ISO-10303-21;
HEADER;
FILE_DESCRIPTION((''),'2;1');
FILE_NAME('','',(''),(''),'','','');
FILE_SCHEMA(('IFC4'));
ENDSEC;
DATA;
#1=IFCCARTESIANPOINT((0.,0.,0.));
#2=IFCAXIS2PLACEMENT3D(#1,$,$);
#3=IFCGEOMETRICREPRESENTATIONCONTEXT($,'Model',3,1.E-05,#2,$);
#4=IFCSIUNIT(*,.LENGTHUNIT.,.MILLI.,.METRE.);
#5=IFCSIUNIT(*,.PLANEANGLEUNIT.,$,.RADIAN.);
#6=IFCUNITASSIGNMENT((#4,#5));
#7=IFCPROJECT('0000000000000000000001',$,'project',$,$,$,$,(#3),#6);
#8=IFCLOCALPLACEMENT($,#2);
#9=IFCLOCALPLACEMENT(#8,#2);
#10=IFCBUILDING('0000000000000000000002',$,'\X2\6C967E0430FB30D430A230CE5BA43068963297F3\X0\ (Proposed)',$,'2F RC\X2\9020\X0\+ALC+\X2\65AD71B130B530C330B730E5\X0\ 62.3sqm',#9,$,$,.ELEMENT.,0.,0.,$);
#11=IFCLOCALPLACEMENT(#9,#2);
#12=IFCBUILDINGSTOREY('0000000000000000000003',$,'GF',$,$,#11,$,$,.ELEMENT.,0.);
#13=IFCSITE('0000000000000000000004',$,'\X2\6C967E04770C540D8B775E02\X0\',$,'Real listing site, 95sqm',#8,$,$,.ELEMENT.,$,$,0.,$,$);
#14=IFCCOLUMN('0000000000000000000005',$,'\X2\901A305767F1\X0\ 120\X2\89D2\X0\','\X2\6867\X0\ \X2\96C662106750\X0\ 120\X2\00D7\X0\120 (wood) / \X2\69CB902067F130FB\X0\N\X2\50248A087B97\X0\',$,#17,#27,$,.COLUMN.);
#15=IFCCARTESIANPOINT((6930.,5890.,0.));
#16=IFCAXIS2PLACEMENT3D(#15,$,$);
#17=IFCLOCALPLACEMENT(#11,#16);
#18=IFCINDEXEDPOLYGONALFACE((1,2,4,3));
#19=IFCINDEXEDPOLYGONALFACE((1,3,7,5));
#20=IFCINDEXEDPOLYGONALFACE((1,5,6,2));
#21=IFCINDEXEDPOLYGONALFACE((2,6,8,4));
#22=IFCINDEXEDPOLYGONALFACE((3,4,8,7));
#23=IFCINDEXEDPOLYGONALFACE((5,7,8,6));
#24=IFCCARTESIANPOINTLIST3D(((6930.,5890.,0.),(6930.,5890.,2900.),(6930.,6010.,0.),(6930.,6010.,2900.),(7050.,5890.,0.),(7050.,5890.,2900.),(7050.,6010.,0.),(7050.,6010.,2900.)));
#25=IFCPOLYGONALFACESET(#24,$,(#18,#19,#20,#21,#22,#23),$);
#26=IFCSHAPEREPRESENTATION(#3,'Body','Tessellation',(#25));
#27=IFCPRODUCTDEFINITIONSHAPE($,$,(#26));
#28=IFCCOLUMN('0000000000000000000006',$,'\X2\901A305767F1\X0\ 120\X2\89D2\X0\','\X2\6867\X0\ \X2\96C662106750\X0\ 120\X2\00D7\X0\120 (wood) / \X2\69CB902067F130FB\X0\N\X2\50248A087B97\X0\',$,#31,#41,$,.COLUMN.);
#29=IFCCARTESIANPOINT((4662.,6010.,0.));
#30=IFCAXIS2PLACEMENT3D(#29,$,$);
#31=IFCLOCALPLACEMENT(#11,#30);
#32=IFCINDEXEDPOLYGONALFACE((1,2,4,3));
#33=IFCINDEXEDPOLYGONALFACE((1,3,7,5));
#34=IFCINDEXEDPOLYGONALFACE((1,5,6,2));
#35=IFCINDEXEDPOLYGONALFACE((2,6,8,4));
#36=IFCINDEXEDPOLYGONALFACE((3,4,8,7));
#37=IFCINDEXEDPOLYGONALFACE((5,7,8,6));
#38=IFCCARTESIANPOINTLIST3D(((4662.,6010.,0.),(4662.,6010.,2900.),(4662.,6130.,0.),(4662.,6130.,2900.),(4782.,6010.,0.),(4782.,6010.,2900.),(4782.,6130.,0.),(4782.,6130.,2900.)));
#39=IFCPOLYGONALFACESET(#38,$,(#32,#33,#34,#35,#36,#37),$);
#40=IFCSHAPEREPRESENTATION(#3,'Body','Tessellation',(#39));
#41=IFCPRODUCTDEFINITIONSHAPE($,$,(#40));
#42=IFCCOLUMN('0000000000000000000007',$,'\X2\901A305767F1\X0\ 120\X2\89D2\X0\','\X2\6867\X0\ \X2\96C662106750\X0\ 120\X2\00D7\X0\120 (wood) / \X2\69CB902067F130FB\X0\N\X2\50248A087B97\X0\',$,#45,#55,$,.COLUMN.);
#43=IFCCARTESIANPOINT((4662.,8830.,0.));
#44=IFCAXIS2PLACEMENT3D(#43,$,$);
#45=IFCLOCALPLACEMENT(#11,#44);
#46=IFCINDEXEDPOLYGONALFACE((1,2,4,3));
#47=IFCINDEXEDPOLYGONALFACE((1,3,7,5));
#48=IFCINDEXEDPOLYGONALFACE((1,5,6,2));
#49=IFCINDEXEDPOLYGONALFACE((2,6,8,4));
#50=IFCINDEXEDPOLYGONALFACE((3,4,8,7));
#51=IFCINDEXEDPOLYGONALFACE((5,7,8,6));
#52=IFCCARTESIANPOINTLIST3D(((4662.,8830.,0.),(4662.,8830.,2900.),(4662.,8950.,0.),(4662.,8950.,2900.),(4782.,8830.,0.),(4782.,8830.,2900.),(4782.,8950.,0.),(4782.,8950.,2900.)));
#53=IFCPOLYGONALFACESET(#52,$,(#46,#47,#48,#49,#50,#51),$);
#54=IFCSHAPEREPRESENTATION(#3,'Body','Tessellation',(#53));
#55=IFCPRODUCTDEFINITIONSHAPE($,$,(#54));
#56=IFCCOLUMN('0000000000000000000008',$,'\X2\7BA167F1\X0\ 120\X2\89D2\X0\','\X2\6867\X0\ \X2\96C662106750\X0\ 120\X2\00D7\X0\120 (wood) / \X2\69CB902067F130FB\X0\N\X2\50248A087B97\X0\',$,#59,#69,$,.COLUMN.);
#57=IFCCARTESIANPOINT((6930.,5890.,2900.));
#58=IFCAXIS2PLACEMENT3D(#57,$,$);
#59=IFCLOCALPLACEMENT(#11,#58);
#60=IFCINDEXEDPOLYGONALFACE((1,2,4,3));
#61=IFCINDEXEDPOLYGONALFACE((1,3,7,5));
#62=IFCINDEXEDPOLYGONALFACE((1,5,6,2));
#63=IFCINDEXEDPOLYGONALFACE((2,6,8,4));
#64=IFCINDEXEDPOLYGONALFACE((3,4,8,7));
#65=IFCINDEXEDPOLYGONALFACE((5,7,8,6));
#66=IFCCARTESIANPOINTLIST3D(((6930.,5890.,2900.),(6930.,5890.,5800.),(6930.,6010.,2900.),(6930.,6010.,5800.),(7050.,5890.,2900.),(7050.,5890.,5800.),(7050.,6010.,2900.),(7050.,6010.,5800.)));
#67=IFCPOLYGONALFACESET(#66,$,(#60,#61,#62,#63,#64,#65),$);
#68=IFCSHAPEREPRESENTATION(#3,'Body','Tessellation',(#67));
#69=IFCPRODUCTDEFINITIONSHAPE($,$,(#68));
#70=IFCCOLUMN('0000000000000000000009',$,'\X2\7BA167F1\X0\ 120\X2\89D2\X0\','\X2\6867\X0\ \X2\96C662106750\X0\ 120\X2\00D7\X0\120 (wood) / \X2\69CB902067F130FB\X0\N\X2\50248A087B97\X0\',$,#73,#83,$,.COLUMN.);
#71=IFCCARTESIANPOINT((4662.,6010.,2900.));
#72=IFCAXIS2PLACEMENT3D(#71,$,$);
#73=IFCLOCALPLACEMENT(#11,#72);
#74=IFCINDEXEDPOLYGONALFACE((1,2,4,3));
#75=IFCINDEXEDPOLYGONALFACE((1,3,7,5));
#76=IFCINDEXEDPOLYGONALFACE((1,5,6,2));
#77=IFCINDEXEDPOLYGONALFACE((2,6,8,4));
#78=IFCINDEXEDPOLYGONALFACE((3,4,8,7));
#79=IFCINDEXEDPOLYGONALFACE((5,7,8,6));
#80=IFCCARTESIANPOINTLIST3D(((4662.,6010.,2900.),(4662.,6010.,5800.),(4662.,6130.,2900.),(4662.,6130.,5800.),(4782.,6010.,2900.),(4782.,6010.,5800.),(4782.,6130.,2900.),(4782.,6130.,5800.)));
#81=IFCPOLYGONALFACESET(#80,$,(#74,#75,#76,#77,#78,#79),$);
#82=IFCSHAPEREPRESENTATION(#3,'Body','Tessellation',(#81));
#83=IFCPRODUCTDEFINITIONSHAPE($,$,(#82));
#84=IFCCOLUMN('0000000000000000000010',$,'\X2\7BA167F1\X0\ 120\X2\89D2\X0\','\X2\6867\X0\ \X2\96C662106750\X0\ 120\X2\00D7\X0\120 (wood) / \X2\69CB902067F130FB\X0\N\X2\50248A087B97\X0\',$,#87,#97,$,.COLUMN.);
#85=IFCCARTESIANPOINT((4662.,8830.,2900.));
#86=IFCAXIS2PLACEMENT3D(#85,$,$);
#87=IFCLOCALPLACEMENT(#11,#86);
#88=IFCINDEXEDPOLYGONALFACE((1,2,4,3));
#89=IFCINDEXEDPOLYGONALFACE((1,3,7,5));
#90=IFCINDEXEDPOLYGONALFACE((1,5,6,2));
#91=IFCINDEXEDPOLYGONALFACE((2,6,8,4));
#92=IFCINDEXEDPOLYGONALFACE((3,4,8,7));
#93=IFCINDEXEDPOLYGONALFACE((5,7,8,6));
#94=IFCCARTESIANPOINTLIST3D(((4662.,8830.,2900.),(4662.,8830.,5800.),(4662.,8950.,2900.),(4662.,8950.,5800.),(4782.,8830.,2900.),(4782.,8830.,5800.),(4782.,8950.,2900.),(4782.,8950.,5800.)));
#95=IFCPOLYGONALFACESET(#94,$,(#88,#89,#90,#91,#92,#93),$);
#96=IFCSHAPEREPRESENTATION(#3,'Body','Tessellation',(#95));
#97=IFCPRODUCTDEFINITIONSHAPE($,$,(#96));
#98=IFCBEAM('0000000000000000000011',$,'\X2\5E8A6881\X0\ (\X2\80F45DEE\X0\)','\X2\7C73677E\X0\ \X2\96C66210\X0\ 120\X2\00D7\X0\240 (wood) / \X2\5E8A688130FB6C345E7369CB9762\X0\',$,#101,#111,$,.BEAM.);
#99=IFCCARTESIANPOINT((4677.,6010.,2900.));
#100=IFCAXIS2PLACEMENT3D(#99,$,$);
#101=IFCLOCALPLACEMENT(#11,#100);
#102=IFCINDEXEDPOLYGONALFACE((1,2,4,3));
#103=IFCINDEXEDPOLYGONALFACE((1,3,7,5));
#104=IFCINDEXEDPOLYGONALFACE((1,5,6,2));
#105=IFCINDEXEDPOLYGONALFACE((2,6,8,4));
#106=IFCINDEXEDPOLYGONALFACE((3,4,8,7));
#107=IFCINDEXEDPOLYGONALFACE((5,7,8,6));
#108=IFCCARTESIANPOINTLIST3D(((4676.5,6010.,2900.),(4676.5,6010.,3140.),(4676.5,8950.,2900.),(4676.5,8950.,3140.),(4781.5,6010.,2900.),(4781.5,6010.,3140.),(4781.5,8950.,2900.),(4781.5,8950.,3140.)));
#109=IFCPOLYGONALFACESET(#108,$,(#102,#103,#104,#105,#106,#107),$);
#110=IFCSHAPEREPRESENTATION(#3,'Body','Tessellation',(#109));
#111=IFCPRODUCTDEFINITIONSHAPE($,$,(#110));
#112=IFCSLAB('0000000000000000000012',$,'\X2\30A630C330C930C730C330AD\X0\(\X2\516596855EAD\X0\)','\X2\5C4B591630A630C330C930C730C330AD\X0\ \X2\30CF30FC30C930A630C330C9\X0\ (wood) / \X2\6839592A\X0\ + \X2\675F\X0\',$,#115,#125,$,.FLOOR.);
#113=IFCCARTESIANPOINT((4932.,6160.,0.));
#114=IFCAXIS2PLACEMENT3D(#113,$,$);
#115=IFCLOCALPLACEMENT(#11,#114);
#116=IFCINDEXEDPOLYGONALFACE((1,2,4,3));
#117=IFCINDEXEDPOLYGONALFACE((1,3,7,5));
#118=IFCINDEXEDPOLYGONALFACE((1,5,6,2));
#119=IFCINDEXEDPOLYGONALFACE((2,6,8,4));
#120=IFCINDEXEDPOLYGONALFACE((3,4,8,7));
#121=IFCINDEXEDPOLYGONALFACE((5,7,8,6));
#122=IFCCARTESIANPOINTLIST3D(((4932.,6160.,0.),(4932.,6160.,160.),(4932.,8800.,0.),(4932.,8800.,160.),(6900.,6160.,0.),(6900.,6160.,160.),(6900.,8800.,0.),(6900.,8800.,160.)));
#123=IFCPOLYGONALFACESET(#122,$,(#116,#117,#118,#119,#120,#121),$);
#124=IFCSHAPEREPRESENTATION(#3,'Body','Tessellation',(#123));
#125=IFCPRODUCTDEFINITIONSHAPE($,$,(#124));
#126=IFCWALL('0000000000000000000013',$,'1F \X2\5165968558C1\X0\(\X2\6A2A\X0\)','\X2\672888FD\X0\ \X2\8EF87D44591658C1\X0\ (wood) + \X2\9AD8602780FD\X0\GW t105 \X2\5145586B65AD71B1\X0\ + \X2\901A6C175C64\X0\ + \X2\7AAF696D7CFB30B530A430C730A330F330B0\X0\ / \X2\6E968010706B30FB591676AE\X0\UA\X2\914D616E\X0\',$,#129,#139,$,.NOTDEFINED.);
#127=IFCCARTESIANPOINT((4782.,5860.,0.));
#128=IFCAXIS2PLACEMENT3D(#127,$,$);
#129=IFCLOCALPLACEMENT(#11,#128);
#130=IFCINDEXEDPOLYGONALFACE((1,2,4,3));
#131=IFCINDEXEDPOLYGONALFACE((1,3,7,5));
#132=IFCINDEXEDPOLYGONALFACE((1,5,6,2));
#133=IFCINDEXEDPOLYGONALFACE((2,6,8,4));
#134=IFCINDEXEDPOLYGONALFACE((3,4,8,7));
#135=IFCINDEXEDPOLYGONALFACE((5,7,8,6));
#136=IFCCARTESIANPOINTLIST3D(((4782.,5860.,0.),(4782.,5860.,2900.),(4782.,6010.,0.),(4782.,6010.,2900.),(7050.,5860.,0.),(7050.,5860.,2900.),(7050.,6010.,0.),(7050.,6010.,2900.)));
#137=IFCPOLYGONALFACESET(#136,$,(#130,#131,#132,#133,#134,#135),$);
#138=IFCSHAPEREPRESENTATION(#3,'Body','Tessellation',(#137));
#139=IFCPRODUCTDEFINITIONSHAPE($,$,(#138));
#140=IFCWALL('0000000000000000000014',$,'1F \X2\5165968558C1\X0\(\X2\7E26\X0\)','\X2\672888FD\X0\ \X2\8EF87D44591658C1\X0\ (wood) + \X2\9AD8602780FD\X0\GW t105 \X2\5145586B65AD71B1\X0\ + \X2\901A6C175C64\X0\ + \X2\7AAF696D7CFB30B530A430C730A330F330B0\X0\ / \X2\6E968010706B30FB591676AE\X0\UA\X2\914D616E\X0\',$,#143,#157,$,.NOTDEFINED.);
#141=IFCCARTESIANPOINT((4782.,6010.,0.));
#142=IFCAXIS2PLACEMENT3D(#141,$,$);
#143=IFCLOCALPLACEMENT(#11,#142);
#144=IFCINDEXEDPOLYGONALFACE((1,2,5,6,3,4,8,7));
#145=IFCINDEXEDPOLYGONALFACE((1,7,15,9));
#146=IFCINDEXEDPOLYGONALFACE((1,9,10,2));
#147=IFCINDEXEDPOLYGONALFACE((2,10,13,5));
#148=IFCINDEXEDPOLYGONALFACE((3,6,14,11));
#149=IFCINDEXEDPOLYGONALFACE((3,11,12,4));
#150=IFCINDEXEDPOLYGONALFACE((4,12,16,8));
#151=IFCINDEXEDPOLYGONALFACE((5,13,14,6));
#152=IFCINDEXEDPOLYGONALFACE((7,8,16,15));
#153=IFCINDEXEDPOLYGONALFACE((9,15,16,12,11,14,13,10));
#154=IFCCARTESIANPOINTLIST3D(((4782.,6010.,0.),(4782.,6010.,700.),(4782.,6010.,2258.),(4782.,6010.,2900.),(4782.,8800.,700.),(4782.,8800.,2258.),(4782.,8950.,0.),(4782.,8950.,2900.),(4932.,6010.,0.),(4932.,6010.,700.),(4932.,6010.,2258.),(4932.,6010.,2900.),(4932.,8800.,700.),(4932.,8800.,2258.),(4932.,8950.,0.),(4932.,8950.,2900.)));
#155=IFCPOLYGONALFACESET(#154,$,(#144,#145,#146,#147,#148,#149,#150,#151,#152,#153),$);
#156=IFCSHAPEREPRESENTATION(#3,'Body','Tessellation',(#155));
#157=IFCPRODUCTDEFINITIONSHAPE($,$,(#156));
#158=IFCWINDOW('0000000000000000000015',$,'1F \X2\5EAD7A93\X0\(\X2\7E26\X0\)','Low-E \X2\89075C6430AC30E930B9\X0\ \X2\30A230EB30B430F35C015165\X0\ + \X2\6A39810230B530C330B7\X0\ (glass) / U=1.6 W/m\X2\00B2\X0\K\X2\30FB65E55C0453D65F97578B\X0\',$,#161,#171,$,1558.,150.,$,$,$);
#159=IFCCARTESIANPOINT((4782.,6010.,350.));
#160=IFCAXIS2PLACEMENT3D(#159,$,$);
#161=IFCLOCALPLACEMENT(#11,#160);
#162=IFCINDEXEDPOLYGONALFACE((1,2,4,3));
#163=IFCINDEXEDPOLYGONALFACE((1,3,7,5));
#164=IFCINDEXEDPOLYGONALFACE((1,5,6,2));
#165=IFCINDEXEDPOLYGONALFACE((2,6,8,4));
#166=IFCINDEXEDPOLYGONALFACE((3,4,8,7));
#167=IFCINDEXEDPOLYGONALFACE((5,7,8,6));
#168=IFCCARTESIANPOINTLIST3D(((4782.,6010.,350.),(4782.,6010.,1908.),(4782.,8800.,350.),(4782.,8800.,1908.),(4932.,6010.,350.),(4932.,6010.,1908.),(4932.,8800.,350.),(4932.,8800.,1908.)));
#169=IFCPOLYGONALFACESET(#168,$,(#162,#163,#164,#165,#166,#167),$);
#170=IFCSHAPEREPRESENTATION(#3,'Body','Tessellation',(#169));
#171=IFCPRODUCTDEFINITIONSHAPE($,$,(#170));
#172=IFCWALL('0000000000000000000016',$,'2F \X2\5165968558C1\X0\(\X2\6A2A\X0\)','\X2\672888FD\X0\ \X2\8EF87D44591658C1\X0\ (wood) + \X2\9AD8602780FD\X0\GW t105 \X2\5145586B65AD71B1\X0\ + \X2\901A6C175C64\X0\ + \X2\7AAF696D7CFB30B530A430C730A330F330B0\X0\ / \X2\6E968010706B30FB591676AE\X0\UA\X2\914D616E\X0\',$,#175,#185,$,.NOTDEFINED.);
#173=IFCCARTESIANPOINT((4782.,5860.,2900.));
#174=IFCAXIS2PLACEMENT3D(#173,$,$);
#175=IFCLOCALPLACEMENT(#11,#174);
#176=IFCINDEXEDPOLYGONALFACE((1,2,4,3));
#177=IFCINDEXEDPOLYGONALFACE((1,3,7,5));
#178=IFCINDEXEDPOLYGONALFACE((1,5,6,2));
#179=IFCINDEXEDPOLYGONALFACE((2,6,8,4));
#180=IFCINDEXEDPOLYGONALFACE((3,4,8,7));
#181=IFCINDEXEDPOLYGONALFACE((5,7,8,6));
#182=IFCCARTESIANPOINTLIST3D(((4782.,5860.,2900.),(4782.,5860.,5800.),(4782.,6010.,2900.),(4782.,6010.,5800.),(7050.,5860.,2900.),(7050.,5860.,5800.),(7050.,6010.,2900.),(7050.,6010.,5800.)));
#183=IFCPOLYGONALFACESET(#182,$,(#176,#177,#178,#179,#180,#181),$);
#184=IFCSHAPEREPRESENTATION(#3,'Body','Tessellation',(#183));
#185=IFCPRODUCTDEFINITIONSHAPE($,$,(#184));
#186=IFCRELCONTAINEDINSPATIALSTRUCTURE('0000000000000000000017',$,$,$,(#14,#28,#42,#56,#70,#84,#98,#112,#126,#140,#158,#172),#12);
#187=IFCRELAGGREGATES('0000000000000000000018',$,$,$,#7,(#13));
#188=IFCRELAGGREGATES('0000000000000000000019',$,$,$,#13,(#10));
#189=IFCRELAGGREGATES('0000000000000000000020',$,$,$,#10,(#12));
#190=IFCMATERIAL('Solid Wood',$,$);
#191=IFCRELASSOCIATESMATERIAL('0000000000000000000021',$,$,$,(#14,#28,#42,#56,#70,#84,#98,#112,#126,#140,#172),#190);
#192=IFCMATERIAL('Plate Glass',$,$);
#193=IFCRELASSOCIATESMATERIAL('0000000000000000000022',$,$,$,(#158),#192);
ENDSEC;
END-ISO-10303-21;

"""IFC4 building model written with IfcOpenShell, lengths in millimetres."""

from ifc_helpers import new_model, si_unit, frame, frame_2d, origin, place, context, project, spatial, rectangle, extrude, material, element, fill, save


model = new_model("IFC4")

# Units and contexts
model_context = context("Model", 3, precision=1e-05, world=origin())
ifc_project = project(units=[si_unit("LENGTHUNIT", "METRE", prefix="MILLI"), si_unit("PLANEANGLEUNIT", "RADIAN")], contexts=[model_context])

# Site, building, storey
site_placement = place(None, origin())
site = spatial("IfcSite", under=ifc_project, at=site_placement, Name="沖縄県名護市", ObjectType="Real listing site, 95sqm", CompositionType="ELEMENT", RefElevation=0.0)
building_placement = place(site_placement, origin())
building = spatial("IfcBuilding", under=site, at=building_placement, Name="沖縄・ピアノ室と防音 (Proposed)", ObjectType="2F RC造+ALC+断熱サッシュ 62.3sqm", CompositionType="ELEMENT", ElevationOfRefHeight=0.0, ElevationOfTerrain=0.0)
storey_placement = place(building_placement, origin())
storey = spatial("IfcBuildingStorey", under=building, at=storey_placement, Name="GF", CompositionType="ELEMENT", Elevation=0.0)

# Columns
ifc_material_1 = material(Name="Solid Wood")
column_1_placement = place(storey_placement, frame((6930.0, 5890.0, 0.0)))
element("IfcColumn", 1, at=column_1_placement, inside=storey, material=ifc_material_1, Name="通し柱 120角", Description="桧 集成材 120×120 (wood) / 構造柱・N値計算", PredefinedType="COLUMN", context=model_context, shape_type="SweptSolid", body=[
    extrude(rectangle(XDim=120.0, YDim=120.0, at=frame_2d((60.0, 60.0))), frame((6930.0, 5890.0, 0.0)), (0.0, 0.0, 1.0), 2900.0),
])
column_2_placement = place(storey_placement, frame((4662.0, 6010.0, 0.0)))
element("IfcColumn", 2, at=column_2_placement, inside=storey, material=ifc_material_1, Name="通し柱 120角", Description="桧 集成材 120×120 (wood) / 構造柱・N値計算", PredefinedType="COLUMN", context=model_context, shape_type="SweptSolid", body=[
    extrude(rectangle(XDim=120.0, YDim=120.0, at=frame_2d((60.0, 60.0))), frame((4662.0, 6010.0, 0.0)), (0.0, 0.0, 1.0), 2900.0),
])
column_3_placement = place(storey_placement, frame((4662.0, 8830.0, 0.0)))
element("IfcColumn", 3, at=column_3_placement, inside=storey, material=ifc_material_1, Name="通し柱 120角", Description="桧 集成材 120×120 (wood) / 構造柱・N値計算", PredefinedType="COLUMN", context=model_context, shape_type="SweptSolid", body=[
    extrude(rectangle(XDim=120.0, YDim=120.0, at=frame_2d((60.0, 60.0))), frame((4662.0, 8830.0, 0.0)), (0.0, 0.0, 1.0), 2900.0),
])
column_4_placement = place(storey_placement, frame((6930.0, 5890.0, 2900.0)))
element("IfcColumn", 4, at=column_4_placement, inside=storey, material=ifc_material_1, Name="管柱 120角", Description="桧 集成材 120×120 (wood) / 構造柱・N値計算", PredefinedType="COLUMN", context=model_context, shape_type="SweptSolid", body=[
    extrude(rectangle(XDim=120.0, YDim=120.0, at=frame_2d((60.0, 60.0))), frame((6930.0, 5890.0, 2900.0)), (0.0, 0.0, 1.0), 2900.0),
])
column_5_placement = place(storey_placement, frame((4662.0, 6010.0, 2900.0)))
element("IfcColumn", 5, at=column_5_placement, inside=storey, material=ifc_material_1, Name="管柱 120角", Description="桧 集成材 120×120 (wood) / 構造柱・N値計算", PredefinedType="COLUMN", context=model_context, shape_type="SweptSolid", body=[
    extrude(rectangle(XDim=120.0, YDim=120.0, at=frame_2d((60.0, 60.0))), frame((4662.0, 6010.0, 2900.0)), (0.0, 0.0, 1.0), 2900.0),
])
column_6_placement = place(storey_placement, frame((4662.0, 8830.0, 2900.0)))
element("IfcColumn", 6, at=column_6_placement, inside=storey, material=ifc_material_1, Name="管柱 120角", Description="桧 集成材 120×120 (wood) / 構造柱・N値計算", PredefinedType="COLUMN", context=model_context, shape_type="SweptSolid", body=[
    extrude(rectangle(XDim=120.0, YDim=120.0, at=frame_2d((60.0, 60.0))), frame((4662.0, 8830.0, 2900.0)), (0.0, 0.0, 1.0), 2900.0),
])

# Beam
beam_1_placement = place(storey_placement, frame((4677.0, 6010.0, 2900.0)))
element("IfcBeam", 7, at=beam_1_placement, inside=storey, material=ifc_material_1, Name="床梁 (胴差)", Description="米松 集成 120×240 (wood) / 床梁・水平構面", PredefinedType="BEAM", context=model_context, shape_type="SweptSolid", body=[
    extrude(rectangle(XDim=105.0, YDim=2940.0, at=frame_2d((52.0, 1470.0))), frame((4677.0, 6010.0, 2900.0)), (0.0, 0.0, 1.0), 240.0),
])

# Slab
slab_placement = place(storey_placement, frame((4932.0, 6160.0, 0.0)))
element("IfcSlab", 8, at=slab_placement, inside=storey, material=ifc_material_1, Name="ウッドデッキ(入隅庭)", Description="屋外ウッドデッキ ハードウッド (wood) / 根太 + 束", PredefinedType="FLOOR", context=model_context, shape_type="SweptSolid", body=[
    extrude(rectangle(XDim=1968.0, YDim=2640.0, at=frame_2d((984.0, 1320.0))), frame((4932.0, 6160.0, 0.0)), (0.0, 0.0, 1.0), 160.0),
])

# Wall
wall_1_placement = place(storey_placement, frame((4782.0, 5860.0, 0.0)))
element("IfcWall", 9, at=wall_1_placement, inside=storey, material=ifc_material_1, Name="1F 入隅壁(横)", Description="木製 軸組外壁 (wood) + 高性能GW t105 充填断熱 + 通気層 + 窯業系サイディング / 準耐火・外皮UA配慮", PredefinedType="NOTDEFINED", context=model_context, shape_type="SweptSolid", body=[
    extrude(rectangle(XDim=2268.0, YDim=150.0, at=frame_2d((1134.0, 75.0))), frame((4782.0, 5860.0, 0.0)), (0.0, 0.0, 1.0), 2900.0),
])

# Wall, opening, window
wall_2_placement = place(storey_placement, frame((4782.0, 6010.0, 0.0)))
wall_2 = element("IfcWall", 10, at=wall_2_placement, inside=storey, material=ifc_material_1, Name="1F 入隅壁(縦)", Description="木製 軸組外壁 (wood) + 高性能GW t105 充填断熱 + 通気層 + 窯業系サイディング / 準耐火・外皮UA配慮", PredefinedType="NOTDEFINED", context=model_context, shape_type="SweptSolid", body=[
    extrude(rectangle(XDim=150.0, YDim=2940.0, at=frame_2d((75.0, 1470.0))), frame((4782.0, 6010.0, 0.0)), (0.0, 0.0, 1.0), 2900.0),
])
opening_1_placement = place(storey_placement, frame((4782.0, 6010.0, 350.0)))
opening_1 = element("IfcOpeningElement", 11, at=opening_1_placement, cuts=wall_2, PredefinedType="NOTDEFINED", context=model_context, shape_type="SweptSolid", body=[
    extrude(rectangle(XDim=150.0, YDim=2790.0, at=frame_2d((75.0, 1395.0))), frame((4782.0, 6010.0, 350.0)), (0.0, 0.0, 1.0), 1558.0),
])
ifc_material_2 = material(Name="Plate Glass")
window_1_placement = place(storey_placement, frame((4782.0, 6010.0, 350.0)))
window_1 = element("IfcWindow", 12, at=window_1_placement, inside=storey, material=ifc_material_2, Name="1F 庭窓(縦)", Description="Low-E 複層ガラス アルゴン封入 + 樹脂サッシ (glass) / U=1.6 W/m²K・日射取得型", OverallHeight=1558.0, OverallWidth=150.0, context=model_context, shape_type="SweptSolid", body=[
    extrude(rectangle(XDim=150.0, YDim=2790.0, at=frame_2d((75.0, 1395.0))), frame((4782.0, 6010.0, 350.0)), (0.0, 0.0, 1.0), 1558.0),
])
fill(opening_1, window_1)

# Wall
wall_3_placement = place(storey_placement, frame((4782.0, 5860.0, 2900.0)))
element("IfcWall", 13, at=wall_3_placement, inside=storey, material=ifc_material_1, Name="2F 入隅壁(横)", Description="木製 軸組外壁 (wood) + 高性能GW t105 充填断熱 + 通気層 + 窯業系サイディング / 準耐火・外皮UA配慮", PredefinedType="NOTDEFINED", context=model_context, shape_type="SweptSolid", body=[
    extrude(rectangle(XDim=2268.0, YDim=150.0, at=frame_2d((1134.0, 75.0))), frame((4782.0, 5860.0, 2900.0)), (0.0, 0.0, 1.0), 2900.0),
])

save(model, "model.ifc")
